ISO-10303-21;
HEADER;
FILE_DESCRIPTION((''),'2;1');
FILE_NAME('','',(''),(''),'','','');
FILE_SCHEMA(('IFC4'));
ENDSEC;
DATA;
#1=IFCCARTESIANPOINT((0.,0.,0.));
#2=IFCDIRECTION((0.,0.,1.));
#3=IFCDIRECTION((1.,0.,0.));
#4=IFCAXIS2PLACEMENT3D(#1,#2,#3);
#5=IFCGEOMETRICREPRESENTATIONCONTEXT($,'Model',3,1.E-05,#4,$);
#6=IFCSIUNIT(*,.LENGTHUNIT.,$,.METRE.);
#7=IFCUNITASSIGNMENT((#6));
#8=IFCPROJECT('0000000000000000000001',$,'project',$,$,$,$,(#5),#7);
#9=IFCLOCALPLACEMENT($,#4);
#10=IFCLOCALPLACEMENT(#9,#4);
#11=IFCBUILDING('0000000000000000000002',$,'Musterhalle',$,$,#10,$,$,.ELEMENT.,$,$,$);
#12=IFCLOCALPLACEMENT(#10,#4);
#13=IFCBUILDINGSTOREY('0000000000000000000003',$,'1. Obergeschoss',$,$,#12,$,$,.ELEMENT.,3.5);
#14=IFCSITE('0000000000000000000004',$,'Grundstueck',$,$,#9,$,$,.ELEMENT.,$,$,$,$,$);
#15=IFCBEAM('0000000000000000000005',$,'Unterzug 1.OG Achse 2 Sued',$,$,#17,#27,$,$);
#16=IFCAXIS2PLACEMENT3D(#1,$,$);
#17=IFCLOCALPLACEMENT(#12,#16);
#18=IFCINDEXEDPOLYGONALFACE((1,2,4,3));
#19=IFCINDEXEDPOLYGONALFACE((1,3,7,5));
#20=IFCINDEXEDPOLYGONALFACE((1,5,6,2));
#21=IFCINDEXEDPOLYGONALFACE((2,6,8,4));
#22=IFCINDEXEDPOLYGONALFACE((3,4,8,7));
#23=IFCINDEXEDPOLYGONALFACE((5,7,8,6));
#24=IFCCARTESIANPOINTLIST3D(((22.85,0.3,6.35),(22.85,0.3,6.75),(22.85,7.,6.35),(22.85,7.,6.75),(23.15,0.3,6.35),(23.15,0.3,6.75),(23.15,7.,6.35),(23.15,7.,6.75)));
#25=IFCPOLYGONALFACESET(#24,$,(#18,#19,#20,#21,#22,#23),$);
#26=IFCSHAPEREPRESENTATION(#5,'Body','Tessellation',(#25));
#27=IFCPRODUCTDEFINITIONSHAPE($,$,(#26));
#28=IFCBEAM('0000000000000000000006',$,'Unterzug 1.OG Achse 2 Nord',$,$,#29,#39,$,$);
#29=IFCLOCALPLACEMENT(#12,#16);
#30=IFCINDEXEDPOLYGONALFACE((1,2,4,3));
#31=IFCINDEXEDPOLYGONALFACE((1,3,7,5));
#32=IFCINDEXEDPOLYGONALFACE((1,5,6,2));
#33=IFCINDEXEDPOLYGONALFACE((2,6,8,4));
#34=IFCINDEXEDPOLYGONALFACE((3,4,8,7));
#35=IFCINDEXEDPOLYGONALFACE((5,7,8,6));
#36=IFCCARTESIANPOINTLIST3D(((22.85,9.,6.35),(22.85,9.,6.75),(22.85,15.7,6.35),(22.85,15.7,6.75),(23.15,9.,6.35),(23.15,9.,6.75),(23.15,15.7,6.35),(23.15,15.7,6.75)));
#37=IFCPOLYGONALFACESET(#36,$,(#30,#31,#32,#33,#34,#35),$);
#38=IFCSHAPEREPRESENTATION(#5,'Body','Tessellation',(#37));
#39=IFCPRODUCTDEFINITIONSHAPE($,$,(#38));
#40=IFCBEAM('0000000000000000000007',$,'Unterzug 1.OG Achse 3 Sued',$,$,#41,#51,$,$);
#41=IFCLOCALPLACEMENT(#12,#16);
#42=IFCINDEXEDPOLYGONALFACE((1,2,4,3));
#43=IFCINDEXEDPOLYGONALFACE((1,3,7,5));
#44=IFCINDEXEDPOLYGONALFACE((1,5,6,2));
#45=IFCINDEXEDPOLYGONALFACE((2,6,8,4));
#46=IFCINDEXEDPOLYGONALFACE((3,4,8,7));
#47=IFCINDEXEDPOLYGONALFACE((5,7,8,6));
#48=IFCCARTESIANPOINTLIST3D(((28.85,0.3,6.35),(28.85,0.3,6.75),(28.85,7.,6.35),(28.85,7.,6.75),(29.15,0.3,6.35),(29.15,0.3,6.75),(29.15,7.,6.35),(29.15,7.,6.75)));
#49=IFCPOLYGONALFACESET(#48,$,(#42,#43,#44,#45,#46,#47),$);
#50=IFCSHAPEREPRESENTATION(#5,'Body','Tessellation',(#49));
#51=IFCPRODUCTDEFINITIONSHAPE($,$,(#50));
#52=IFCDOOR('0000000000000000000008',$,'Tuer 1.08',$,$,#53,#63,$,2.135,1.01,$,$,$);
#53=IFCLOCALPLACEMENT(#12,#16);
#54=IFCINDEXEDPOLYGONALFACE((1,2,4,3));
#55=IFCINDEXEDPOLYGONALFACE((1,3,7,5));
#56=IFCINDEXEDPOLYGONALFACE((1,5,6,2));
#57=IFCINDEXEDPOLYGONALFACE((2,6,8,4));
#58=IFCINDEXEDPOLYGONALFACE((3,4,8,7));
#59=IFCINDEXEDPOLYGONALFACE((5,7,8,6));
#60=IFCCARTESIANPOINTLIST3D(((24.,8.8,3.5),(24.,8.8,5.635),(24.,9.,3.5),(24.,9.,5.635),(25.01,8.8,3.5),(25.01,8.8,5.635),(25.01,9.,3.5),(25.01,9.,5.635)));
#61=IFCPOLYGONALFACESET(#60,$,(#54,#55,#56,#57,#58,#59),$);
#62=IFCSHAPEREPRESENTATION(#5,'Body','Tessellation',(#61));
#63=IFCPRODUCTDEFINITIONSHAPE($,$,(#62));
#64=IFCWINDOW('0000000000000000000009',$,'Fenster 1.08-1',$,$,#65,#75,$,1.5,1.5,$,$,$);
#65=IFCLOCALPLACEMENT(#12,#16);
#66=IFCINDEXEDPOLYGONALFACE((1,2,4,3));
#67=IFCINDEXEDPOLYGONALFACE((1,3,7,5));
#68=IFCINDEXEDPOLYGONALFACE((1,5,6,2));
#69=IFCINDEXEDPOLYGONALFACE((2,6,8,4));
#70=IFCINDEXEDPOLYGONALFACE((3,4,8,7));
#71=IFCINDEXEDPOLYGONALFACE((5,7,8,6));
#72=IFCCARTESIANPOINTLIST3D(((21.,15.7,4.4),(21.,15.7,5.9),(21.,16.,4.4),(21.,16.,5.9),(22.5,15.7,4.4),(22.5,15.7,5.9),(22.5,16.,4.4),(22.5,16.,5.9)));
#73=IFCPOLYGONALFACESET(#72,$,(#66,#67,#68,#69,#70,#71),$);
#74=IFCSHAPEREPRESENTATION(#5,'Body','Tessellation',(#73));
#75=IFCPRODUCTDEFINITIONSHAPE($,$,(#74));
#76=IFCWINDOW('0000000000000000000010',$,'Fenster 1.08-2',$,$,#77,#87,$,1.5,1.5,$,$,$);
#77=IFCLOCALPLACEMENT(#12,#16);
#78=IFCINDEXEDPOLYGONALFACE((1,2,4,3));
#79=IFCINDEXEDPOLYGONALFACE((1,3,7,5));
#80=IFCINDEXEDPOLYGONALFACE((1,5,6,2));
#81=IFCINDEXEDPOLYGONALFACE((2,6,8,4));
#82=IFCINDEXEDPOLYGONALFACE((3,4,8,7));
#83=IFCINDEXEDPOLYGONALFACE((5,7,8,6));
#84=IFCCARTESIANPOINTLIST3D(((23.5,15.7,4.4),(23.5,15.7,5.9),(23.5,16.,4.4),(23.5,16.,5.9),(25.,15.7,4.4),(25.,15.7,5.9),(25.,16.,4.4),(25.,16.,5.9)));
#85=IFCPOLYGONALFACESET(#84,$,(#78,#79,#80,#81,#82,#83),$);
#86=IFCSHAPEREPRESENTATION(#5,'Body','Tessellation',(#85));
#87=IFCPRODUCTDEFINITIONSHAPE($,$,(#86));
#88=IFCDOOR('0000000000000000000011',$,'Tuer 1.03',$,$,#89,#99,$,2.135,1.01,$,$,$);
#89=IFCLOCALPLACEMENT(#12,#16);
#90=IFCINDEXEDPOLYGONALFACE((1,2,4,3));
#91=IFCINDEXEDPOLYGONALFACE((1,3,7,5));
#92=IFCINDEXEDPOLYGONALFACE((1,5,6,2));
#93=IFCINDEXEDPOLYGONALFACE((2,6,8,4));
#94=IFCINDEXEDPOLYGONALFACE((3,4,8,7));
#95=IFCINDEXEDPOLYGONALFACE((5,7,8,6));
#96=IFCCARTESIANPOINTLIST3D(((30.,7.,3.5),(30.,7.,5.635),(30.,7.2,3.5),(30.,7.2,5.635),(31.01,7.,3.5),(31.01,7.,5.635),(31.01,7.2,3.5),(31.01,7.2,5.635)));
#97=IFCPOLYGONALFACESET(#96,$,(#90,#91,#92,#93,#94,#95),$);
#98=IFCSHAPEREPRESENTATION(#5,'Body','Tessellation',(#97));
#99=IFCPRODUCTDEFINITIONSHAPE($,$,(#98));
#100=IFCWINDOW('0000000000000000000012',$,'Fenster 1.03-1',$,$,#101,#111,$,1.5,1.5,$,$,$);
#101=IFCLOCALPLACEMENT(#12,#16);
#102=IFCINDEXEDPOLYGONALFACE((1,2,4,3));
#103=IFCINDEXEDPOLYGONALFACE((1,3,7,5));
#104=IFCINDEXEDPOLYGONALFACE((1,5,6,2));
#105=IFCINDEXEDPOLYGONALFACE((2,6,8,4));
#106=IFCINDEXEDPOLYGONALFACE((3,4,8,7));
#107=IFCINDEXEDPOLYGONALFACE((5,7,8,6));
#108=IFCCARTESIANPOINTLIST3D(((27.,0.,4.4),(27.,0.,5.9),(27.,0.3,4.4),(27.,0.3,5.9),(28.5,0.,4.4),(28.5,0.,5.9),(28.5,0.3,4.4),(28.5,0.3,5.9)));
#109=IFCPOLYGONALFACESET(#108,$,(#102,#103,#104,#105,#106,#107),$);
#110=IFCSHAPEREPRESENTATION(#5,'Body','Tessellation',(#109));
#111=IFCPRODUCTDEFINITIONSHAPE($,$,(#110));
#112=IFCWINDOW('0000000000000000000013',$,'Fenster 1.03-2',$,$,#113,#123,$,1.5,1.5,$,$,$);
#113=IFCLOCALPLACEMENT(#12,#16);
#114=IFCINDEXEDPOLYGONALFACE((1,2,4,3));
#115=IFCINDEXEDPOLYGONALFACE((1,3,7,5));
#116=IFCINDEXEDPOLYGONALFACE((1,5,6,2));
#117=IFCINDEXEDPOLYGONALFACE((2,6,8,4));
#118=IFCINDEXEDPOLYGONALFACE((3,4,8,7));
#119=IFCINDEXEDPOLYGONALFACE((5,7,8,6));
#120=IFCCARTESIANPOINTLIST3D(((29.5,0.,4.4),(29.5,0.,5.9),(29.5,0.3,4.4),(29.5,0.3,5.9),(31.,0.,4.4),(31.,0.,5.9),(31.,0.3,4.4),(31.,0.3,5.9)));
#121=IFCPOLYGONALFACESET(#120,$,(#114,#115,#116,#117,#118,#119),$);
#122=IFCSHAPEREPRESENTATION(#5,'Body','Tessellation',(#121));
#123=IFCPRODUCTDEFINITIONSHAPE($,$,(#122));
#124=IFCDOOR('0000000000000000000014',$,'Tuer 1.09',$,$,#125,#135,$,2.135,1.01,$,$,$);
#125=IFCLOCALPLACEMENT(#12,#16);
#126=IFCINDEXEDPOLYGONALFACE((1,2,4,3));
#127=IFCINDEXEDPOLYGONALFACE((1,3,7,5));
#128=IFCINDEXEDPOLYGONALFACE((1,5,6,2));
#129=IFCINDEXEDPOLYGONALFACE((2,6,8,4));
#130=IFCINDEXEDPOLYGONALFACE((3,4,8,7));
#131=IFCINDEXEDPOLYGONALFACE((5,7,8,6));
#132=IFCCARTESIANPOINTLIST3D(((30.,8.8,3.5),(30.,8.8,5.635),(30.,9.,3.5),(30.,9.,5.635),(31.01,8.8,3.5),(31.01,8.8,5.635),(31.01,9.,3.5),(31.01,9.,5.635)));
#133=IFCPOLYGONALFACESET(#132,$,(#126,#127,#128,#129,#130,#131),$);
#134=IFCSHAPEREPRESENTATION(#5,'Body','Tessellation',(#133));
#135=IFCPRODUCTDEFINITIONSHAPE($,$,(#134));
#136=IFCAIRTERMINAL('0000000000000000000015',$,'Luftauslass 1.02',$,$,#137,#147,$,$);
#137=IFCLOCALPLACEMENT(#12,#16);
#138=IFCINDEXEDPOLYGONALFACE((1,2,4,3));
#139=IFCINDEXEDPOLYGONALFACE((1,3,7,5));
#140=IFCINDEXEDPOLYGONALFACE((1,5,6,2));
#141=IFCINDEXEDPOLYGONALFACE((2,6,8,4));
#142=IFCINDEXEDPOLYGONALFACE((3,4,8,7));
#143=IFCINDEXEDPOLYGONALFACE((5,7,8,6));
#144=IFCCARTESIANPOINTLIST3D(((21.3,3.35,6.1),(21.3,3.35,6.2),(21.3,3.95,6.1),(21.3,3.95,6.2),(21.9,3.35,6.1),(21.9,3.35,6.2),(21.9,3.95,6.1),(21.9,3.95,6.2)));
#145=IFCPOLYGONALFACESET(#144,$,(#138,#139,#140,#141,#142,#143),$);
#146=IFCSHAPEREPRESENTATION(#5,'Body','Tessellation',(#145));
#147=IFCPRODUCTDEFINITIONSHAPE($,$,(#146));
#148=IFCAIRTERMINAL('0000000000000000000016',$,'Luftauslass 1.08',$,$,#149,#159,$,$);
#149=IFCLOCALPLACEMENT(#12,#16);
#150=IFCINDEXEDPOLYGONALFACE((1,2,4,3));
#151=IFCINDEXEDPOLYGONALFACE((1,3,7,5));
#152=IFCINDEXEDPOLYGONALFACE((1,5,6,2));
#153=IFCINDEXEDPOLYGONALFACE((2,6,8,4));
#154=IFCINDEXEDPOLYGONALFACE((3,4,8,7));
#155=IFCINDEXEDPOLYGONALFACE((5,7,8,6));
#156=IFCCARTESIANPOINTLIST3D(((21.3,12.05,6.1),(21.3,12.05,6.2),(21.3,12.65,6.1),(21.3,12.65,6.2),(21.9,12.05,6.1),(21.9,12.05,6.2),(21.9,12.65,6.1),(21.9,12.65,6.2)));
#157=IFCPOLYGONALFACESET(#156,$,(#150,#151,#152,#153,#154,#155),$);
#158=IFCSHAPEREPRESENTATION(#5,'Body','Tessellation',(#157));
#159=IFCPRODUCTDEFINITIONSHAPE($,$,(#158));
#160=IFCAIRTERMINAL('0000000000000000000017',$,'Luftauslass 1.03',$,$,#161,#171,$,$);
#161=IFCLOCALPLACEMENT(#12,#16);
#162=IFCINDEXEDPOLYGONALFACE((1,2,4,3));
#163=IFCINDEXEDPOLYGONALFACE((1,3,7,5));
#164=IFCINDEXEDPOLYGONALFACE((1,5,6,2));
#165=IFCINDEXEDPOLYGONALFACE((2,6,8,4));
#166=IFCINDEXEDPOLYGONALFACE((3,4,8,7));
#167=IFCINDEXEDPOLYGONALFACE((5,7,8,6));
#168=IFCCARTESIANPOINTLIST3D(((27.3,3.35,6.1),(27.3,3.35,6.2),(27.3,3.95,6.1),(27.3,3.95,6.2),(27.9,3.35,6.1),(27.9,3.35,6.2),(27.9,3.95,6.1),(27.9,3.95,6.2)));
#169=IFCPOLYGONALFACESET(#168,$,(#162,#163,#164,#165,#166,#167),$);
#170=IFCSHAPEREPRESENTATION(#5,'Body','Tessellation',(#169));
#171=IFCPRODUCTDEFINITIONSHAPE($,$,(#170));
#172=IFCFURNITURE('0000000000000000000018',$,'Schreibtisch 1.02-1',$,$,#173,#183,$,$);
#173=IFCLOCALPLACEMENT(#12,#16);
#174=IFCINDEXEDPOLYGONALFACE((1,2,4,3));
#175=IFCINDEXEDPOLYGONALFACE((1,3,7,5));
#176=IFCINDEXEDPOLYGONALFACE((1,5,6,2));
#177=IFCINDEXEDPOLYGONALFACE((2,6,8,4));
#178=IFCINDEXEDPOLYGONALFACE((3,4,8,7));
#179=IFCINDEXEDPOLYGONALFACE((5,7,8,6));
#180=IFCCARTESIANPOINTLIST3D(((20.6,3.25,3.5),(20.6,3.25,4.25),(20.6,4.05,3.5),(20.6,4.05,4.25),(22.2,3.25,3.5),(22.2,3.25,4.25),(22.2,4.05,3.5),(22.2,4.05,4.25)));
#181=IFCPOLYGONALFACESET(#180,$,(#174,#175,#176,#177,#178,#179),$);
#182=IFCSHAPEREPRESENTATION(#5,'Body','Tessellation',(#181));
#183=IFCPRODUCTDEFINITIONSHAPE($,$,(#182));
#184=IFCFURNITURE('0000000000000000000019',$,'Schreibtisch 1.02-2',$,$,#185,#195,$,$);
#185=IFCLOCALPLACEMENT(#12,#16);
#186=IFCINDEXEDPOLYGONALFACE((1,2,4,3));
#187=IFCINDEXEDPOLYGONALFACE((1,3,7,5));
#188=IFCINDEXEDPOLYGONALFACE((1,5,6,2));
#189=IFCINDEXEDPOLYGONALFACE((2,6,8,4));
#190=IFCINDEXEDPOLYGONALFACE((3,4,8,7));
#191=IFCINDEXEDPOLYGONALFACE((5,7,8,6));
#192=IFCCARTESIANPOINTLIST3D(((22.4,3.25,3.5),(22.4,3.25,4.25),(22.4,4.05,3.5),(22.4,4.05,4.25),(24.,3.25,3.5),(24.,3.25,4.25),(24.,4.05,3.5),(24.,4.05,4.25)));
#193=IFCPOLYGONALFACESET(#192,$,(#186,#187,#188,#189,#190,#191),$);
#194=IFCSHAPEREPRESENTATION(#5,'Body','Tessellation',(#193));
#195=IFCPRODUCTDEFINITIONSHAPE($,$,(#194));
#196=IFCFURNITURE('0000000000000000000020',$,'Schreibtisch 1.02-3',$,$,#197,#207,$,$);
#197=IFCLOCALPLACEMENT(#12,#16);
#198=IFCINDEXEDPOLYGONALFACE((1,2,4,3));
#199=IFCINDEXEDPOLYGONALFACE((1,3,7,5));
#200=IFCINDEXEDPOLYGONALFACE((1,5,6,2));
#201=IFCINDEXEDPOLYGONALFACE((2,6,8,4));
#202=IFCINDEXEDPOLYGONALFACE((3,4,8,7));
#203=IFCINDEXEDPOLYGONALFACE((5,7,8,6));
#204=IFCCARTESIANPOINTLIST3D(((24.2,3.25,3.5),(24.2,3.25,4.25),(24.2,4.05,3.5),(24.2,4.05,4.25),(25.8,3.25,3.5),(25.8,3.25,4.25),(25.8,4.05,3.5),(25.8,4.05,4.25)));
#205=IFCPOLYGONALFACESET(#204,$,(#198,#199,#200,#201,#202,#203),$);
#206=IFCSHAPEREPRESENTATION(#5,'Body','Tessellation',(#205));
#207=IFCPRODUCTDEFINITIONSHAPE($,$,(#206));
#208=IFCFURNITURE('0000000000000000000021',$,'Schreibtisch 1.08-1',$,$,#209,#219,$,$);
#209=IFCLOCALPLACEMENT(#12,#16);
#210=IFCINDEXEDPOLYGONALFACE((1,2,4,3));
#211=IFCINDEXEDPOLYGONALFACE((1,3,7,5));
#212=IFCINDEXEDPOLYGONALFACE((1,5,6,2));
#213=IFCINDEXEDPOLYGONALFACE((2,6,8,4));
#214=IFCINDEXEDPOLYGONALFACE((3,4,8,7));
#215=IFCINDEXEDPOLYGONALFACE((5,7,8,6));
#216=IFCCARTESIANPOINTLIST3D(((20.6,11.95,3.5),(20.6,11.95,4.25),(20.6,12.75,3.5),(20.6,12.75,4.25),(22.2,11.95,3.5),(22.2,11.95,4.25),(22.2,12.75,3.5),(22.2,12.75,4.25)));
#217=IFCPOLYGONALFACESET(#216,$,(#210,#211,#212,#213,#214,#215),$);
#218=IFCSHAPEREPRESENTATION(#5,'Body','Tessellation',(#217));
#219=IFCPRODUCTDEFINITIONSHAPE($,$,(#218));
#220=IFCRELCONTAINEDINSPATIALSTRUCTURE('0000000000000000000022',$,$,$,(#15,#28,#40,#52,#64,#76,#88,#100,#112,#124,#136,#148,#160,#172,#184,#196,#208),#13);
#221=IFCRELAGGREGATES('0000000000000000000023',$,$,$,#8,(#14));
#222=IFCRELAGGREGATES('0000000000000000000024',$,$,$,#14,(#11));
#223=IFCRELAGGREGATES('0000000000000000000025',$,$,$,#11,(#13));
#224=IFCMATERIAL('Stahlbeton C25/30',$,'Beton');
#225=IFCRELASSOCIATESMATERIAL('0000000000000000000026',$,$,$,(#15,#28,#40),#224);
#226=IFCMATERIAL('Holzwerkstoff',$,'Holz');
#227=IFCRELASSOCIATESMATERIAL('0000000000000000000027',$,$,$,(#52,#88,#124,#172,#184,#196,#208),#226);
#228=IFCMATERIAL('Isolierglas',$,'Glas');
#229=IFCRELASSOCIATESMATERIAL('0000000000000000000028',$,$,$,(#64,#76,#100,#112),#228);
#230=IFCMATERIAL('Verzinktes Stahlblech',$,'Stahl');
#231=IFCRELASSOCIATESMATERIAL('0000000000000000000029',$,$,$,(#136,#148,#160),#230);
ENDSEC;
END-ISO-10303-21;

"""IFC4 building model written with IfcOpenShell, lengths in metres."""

from ifc_helpers import new_model, si_unit, frame, origin_with_axes, origin_2d, place, context, project, spatial, rectangle, extrude, material, element, save


model = new_model("IFC4")

# Units and contexts
model_context = context("Model", 3, precision=1e-05, world=origin_with_axes())
ifc_project = project(units=[si_unit("LENGTHUNIT", "METRE")], contexts=[model_context])

# Site, building, storey
site_placement = place(None, origin_with_axes())
site = spatial("IfcSite", under=ifc_project, at=site_placement, Name="Grundstueck", CompositionType="ELEMENT")
building_placement = place(site_placement, origin_with_axes())
building = spatial("IfcBuilding", under=site, at=building_placement, Name="Musterhalle", CompositionType="ELEMENT")
storey_placement = place(building_placement, origin_with_axes())
storey = spatial("IfcBuildingStorey", under=building, at=storey_placement, Name="1. Obergeschoss", CompositionType="ELEMENT", Elevation=3.5)

# Beams
ifc_material_1 = material(Name="Stahlbeton C25/30", Category="Beton")
placement = place(storey_placement, origin_with_axes())
element("IfcBeam", 1, at=placement, inside=storey, material=ifc_material_1, Name="Unterzug 1.OG Achse 2 Sued", context=model_context, shape_type="SweptSolid", body=[
    extrude(rectangle(XDim=0.3, YDim=6.7, at=origin_2d()), frame((23.0, 3.65, 6.35), z_axis=(0.0, 0.0, 1.0), x_axis=(1.0, 0.0, 0.0)), (0.0, 0.0, 1.0), 0.4),
])
element("IfcBeam", 2, at=placement, inside=storey, material=ifc_material_1, Name="Unterzug 1.OG Achse 2 Nord", context=model_context, shape_type="SweptSolid", body=[
    extrude(rectangle(XDim=0.3, YDim=6.7, at=origin_2d()), frame((23.0, 12.35, 6.35), z_axis=(0.0, 0.0, 1.0), x_axis=(1.0, 0.0, 0.0)), (0.0, 0.0, 1.0), 0.4),
])
element("IfcBeam", 3, at=placement, inside=storey, material=ifc_material_1, Name="Unterzug 1.OG Achse 3 Sued", context=model_context, shape_type="SweptSolid", body=[
    extrude(rectangle(XDim=0.3, YDim=6.7, at=origin_2d()), frame((29.0, 3.65, 6.35), z_axis=(0.0, 0.0, 1.0), x_axis=(1.0, 0.0, 0.0)), (0.0, 0.0, 1.0), 0.4),
])

# Door
ifc_material_2 = material(Name="Holzwerkstoff", Category="Holz")
element("IfcDoor", 4, at=placement, inside=storey, material=ifc_material_2, Name="Tuer 1.08", OverallHeight=2.135, OverallWidth=1.01, context=model_context, shape_type="SweptSolid", body=[
    extrude(rectangle(XDim=1.01, YDim=0.2, at=origin_2d()), frame((24.505, 8.9, 3.5), z_axis=(0.0, 0.0, 1.0), x_axis=(1.0, 0.0, 0.0)), (0.0, 0.0, 1.0), 2.135),
])

# Windows
ifc_material_3 = material(Name="Isolierglas", Category="Glas")
element("IfcWindow", 5, at=placement, inside=storey, material=ifc_material_3, Name="Fenster 1.08-1", OverallHeight=1.5, OverallWidth=1.5, context=model_context, shape_type="SweptSolid", body=[
    extrude(rectangle(XDim=1.5, YDim=0.3, at=origin_2d()), frame((21.75, 15.85, 4.4), z_axis=(0.0, 0.0, 1.0), x_axis=(1.0, 0.0, 0.0)), (0.0, 0.0, 1.0), 1.5),
])
element("IfcWindow", 6, at=placement, inside=storey, material=ifc_material_3, Name="Fenster 1.08-2", OverallHeight=1.5, OverallWidth=1.5, context=model_context, shape_type="SweptSolid", body=[
    extrude(rectangle(XDim=1.5, YDim=0.3, at=origin_2d()), frame((24.25, 15.85, 4.4), z_axis=(0.0, 0.0, 1.0), x_axis=(1.0, 0.0, 0.0)), (0.0, 0.0, 1.0), 1.5),
])

# Door
element("IfcDoor", 7, at=placement, inside=storey, material=ifc_material_2, Name="Tuer 1.03", OverallHeight=2.135, OverallWidth=1.01, context=model_context, shape_type="SweptSolid", body=[
    extrude(rectangle(XDim=1.01, YDim=0.2, at=origin_2d()), frame((30.505, 7.1, 3.5), z_axis=(0.0, 0.0, 1.0), x_axis=(1.0, 0.0, 0.0)), (0.0, 0.0, 1.0), 2.135),
])

# Windows
element("IfcWindow", 8, at=placement, inside=storey, material=ifc_material_3, Name="Fenster 1.03-1", OverallHeight=1.5, OverallWidth=1.5, context=model_context, shape_type="SweptSolid", body=[
    extrude(rectangle(XDim=1.5, YDim=0.3, at=origin_2d()), frame((27.75, 0.15, 4.4), z_axis=(0.0, 0.0, 1.0), x_axis=(1.0, 0.0, 0.0)), (0.0, 0.0, 1.0), 1.5),
])
element("IfcWindow", 9, at=placement, inside=storey, material=ifc_material_3, Name="Fenster 1.03-2", OverallHeight=1.5, OverallWidth=1.5, context=model_context, shape_type="SweptSolid", body=[
    extrude(rectangle(XDim=1.5, YDim=0.3, at=origin_2d()), frame((30.25, 0.15, 4.4), z_axis=(0.0, 0.0, 1.0), x_axis=(1.0, 0.0, 0.0)), (0.0, 0.0, 1.0), 1.5),
])

# Door
element("IfcDoor", 10, at=placement, inside=storey, material=ifc_material_2, Name="Tuer 1.09", OverallHeight=2.135, OverallWidth=1.01, context=model_context, shape_type="SweptSolid", body=[
    extrude(rectangle(XDim=1.01, YDim=0.2, at=origin_2d()), frame((30.505, 8.9, 3.5), z_axis=(0.0, 0.0, 1.0), x_axis=(1.0, 0.0, 0.0)), (0.0, 0.0, 1.0), 2.135),
])

# Air terminals
ifc_material_4 = material(Name="Verzinktes Stahlblech", Category="Stahl")
element("IfcAirTerminal", 11, at=placement, inside=storey, material=ifc_material_4, Name="Luftauslass 1.02", context=model_context, shape_type="SweptSolid", body=[
    extrude(rectangle(XDim=0.6, YDim=0.6, at=origin_2d()), frame((21.6, 3.65, 6.1), z_axis=(0.0, 0.0, 1.0), x_axis=(1.0, 0.0, 0.0)), (0.0, 0.0, 1.0), 0.1),
])
element("IfcAirTerminal", 12, at=placement, inside=storey, material=ifc_material_4, Name="Luftauslass 1.08", context=model_context, shape_type="SweptSolid", body=[
    extrude(rectangle(XDim=0.6, YDim=0.6, at=origin_2d()), frame((21.6, 12.35, 6.1), z_axis=(0.0, 0.0, 1.0), x_axis=(1.0, 0.0, 0.0)), (0.0, 0.0, 1.0), 0.1),
])
element("IfcAirTerminal", 13, at=placement, inside=storey, material=ifc_material_4, Name="Luftauslass 1.03", context=model_context, shape_type="SweptSolid", body=[
    extrude(rectangle(XDim=0.6, YDim=0.6, at=origin_2d()), frame((27.6, 3.65, 6.1), z_axis=(0.0, 0.0, 1.0), x_axis=(1.0, 0.0, 0.0)), (0.0, 0.0, 1.0), 0.1),
])

# Furniture
element("IfcFurniture", 14, at=placement, inside=storey, material=ifc_material_2, Name="Schreibtisch 1.02-1", context=model_context, shape_type="SweptSolid", body=[
    extrude(rectangle(XDim=1.6, YDim=0.8, at=origin_2d()), frame((21.4, 3.65, 3.5), z_axis=(0.0, 0.0, 1.0), x_axis=(1.0, 0.0, 0.0)), (0.0, 0.0, 1.0), 0.75),
])
element("IfcFurniture", 15, at=placement, inside=storey, material=ifc_material_2, Name="Schreibtisch 1.02-2", context=model_context, shape_type="SweptSolid", body=[
    extrude(rectangle(XDim=1.6, YDim=0.8, at=origin_2d()), frame((23.2, 3.65, 3.5), z_axis=(0.0, 0.0, 1.0), x_axis=(1.0, 0.0, 0.0)), (0.0, 0.0, 1.0), 0.75),
])
element("IfcFurniture", 16, at=placement, inside=storey, material=ifc_material_2, Name="Schreibtisch 1.02-3", context=model_context, shape_type="SweptSolid", body=[
    extrude(rectangle(XDim=1.6, YDim=0.8, at=origin_2d()), frame((25.0, 3.65, 3.5), z_axis=(0.0, 0.0, 1.0), x_axis=(1.0, 0.0, 0.0)), (0.0, 0.0, 1.0), 0.75),
])
element("IfcFurniture", 17, at=placement, inside=storey, material=ifc_material_2, Name="Schreibtisch 1.08-1", context=model_context, shape_type="SweptSolid", body=[
    extrude(rectangle(XDim=1.6, YDim=0.8, at=origin_2d()), frame((21.4, 12.35, 3.5), z_axis=(0.0, 0.0, 1.0), x_axis=(1.0, 0.0, 0.0)), (0.0, 0.0, 1.0), 0.75),
])

save(model, "model.ifc")
